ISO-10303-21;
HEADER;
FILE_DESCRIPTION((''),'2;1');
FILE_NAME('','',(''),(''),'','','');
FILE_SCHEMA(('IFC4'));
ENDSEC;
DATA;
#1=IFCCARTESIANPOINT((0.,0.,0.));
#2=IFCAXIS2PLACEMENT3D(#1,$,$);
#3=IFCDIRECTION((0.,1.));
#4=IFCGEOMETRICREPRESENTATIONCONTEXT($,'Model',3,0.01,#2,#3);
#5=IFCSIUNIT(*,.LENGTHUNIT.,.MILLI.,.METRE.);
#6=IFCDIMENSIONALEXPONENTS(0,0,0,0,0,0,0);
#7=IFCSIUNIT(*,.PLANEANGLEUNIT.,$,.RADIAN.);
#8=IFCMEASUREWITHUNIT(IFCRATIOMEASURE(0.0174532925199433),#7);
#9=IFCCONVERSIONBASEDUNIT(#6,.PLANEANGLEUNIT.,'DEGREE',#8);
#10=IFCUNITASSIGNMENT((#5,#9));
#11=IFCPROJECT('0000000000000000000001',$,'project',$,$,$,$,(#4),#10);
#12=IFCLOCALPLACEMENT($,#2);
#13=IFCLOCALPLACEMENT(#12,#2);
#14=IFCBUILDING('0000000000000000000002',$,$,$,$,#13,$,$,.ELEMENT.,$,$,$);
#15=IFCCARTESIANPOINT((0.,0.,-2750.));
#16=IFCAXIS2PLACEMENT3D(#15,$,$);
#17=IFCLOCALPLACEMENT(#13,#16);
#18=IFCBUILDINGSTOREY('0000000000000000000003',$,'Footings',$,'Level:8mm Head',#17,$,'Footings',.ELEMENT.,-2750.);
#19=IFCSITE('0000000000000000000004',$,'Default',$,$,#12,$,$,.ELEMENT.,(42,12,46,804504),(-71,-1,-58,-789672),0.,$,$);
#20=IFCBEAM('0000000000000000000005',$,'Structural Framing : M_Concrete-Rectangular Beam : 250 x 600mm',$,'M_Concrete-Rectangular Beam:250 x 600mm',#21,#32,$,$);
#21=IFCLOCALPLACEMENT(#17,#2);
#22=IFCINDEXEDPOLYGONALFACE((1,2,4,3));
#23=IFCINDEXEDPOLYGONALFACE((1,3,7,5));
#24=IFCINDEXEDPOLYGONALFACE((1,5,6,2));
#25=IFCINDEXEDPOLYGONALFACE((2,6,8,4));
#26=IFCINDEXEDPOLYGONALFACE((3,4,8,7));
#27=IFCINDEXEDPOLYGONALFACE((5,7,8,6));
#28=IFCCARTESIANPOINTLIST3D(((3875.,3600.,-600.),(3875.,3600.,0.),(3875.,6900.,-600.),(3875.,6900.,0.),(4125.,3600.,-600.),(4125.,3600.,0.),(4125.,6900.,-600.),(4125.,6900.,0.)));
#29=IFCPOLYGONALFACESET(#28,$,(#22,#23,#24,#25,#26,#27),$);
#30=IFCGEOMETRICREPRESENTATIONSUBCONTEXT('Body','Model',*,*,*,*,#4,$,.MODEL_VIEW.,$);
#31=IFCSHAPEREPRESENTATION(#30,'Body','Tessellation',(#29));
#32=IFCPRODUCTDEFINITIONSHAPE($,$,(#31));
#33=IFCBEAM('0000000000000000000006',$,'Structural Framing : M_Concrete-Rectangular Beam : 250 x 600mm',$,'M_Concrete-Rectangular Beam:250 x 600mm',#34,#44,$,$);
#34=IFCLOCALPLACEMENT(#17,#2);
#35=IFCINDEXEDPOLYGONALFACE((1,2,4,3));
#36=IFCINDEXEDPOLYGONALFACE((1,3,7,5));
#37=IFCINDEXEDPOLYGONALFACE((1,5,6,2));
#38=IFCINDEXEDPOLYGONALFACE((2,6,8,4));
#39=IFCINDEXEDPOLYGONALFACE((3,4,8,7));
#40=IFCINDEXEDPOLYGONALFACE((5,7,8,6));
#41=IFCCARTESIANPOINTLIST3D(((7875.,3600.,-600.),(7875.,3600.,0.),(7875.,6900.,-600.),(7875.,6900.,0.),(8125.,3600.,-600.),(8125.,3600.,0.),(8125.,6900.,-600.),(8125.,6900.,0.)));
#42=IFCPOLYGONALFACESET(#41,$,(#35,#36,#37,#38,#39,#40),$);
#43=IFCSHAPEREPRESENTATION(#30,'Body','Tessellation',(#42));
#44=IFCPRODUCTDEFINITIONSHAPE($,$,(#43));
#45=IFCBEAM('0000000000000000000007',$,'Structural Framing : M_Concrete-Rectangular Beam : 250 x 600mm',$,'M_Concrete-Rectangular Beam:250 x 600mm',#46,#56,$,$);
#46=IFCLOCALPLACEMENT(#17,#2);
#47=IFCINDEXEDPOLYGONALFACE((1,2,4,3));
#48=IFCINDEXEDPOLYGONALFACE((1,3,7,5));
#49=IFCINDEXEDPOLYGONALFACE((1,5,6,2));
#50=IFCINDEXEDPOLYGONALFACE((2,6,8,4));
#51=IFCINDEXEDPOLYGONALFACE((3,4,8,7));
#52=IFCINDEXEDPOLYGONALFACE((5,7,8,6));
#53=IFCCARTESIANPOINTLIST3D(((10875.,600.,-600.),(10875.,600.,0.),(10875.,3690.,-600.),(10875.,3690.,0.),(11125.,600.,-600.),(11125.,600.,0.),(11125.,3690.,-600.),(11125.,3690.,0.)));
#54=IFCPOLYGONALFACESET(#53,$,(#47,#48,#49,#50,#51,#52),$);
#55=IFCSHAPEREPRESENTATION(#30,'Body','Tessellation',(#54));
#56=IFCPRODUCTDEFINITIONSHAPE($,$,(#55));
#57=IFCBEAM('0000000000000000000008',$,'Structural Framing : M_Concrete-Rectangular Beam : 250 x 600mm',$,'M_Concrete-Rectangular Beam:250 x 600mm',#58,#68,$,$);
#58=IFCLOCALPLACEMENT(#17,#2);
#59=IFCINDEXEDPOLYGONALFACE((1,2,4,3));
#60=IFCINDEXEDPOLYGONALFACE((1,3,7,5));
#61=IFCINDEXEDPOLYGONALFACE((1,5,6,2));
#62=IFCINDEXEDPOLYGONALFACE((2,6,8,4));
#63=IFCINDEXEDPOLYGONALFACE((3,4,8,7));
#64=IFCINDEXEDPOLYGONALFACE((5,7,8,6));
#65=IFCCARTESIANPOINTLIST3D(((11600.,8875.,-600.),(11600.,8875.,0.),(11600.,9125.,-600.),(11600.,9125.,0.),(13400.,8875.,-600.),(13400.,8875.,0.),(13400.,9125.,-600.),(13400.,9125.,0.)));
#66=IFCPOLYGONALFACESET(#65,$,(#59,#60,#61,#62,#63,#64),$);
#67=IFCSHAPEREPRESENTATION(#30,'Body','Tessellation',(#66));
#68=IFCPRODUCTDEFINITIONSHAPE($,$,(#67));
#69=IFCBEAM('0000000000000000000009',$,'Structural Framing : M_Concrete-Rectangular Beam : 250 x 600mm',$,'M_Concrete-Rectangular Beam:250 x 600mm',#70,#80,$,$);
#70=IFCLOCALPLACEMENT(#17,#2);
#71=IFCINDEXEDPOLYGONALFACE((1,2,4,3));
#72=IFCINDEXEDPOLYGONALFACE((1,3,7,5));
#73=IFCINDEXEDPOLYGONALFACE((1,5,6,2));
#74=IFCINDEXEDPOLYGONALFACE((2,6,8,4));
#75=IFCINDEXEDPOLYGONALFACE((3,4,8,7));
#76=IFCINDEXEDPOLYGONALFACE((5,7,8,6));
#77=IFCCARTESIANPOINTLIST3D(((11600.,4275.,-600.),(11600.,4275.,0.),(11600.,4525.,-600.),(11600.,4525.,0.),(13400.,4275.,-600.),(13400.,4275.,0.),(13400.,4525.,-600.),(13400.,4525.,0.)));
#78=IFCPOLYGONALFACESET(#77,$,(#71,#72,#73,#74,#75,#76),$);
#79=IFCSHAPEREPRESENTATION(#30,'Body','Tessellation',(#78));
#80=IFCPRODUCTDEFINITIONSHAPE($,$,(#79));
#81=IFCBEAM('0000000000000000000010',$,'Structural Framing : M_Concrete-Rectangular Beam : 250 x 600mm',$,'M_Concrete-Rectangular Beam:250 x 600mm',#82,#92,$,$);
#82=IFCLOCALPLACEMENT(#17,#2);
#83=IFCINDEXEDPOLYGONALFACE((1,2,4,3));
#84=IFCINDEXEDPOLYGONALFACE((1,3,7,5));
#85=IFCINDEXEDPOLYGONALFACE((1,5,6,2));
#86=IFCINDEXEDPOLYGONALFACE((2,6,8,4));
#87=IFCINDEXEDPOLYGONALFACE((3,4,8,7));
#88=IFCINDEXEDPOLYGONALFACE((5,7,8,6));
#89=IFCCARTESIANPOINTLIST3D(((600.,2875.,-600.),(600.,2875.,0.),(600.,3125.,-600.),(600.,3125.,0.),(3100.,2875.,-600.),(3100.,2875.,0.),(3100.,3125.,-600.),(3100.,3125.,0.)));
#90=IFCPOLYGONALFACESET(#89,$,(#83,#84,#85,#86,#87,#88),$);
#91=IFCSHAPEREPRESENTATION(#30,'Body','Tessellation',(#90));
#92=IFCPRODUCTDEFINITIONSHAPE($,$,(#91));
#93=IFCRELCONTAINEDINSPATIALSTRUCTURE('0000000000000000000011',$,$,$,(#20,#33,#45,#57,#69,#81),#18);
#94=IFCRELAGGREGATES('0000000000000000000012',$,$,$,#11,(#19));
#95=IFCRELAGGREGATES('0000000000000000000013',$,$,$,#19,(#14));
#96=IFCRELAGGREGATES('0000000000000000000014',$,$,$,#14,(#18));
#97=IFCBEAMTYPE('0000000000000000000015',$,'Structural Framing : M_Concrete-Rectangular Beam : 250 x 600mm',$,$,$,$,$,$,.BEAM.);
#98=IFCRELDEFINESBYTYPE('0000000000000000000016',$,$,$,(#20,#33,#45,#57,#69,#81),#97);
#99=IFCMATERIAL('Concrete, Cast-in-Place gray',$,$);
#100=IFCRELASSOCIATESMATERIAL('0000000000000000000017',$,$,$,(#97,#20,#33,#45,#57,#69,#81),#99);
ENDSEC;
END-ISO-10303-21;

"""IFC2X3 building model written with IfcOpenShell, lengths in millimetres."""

from ifc_helpers import new_model, entity, si_unit, converted_unit, direction, frame, frame_2d, origin, origin_2d_with_axis, place, context, subcontext, project, spatial, rectangle, extrude, material, type_object, element, save


model = new_model("IFC2X3")

# Units and contexts
model_context = context("Model", 3, precision=0.01, world=origin(), true_north=direction((0.0, 1.0)))
body_context = subcontext(model_context, "Body", "Model", "MODEL_VIEW")
ifc_project = project(units=[si_unit("LENGTHUNIT", "METRE", prefix="MILLI"), converted_unit("PLANEANGLEUNIT", "DEGREE", entity("IfcRatioMeasure", 0.0174532925199433), si_unit("PLANEANGLEUNIT", "RADIAN"), dimensions=[0, 0, 0, 0, 0, 0, 0])], contexts=[model_context])

# Site, building, storey
site_placement = place(None, origin())
site = spatial("IfcSite", under=ifc_project, at=site_placement, Name="Default", CompositionType="ELEMENT", RefLatitude=(42, 12, 46, 804504), RefLongitude=(-71, -1, -58, -789672), RefElevation=0.0)
building_placement = place(site_placement, origin())
building = spatial("IfcBuilding", under=site, at=building_placement, CompositionType="ELEMENT")
storey_placement = place(building_placement, frame((0.0, 0.0, -2750.0)))
storey = spatial("IfcBuildingStorey", under=building, at=storey_placement, Name="Footings", ObjectType="Level:8mm Head", LongName="Footings", CompositionType="ELEMENT", Elevation=-2750.0)

# Beams
ifc_material = material(Name="Concrete, Cast-in-Place gray")
beam_type = type_object("IfcBeamType", Name="Structural Framing : M_Concrete-Rectangular Beam : 250 x 600mm", PredefinedType="BEAM", material=ifc_material)
beam_1_placement = place(storey_placement, frame((4000.0, 3000.0, 0.0), z_axis=(0.0, 0.0, 1.0), x_axis=(0.0, 1.0, 0.0)))
element("IfcBeam", 1, at=beam_1_placement, inside=storey, type_object=beam_type, material=ifc_material, Name="Structural Framing : M_Concrete-Rectangular Beam : 250 x 600mm", ObjectType="M_Concrete-Rectangular Beam:250 x 600mm", context=body_context, shape_type="SweptSolid", body=[
    extrude(rectangle(XDim=600.0, YDim=250.0, at=frame_2d((0.0, 0.0), x_axis=(1.0, 0.0))), frame((600.0, 0.0, -300.0), z_axis=(1.0, 0.0, 0.0), x_axis=(0.0, 0.0, -1.0)), (0.0, 0.0, 1.0), 3300.0),
])
beam_2_placement = place(storey_placement, frame((8000.0, 3000.0, 0.0), z_axis=(0.0, 0.0, 1.0), x_axis=(0.0, 1.0, 0.0)))
element("IfcBeam", 2, at=beam_2_placement, inside=storey, type_object=beam_type, material=ifc_material, Name="Structural Framing : M_Concrete-Rectangular Beam : 250 x 600mm", ObjectType="M_Concrete-Rectangular Beam:250 x 600mm", context=body_context, shape_type="SweptSolid", body=[
    extrude(rectangle(XDim=600.0, YDim=250.0, at=frame_2d((0.0, 0.0), x_axis=(1.0, 0.0))), frame((600.0, 0.0, -300.0), z_axis=(1.0, 0.0, 0.0), x_axis=(0.0, 0.0, -1.0)), (0.0, 0.0, 1.0), 3300.0),
])
beam_3_placement = place(storey_placement, frame((11000.0, 0.0, 0.0), z_axis=(0.0, 0.0, 1.0), x_axis=(0.0, 1.0, 0.0)))
element("IfcBeam", 3, at=beam_3_placement, inside=storey, type_object=beam_type, material=ifc_material, Name="Structural Framing : M_Concrete-Rectangular Beam : 250 x 600mm", ObjectType="M_Concrete-Rectangular Beam:250 x 600mm", context=body_context, shape_type="SweptSolid", body=[
    extrude(rectangle(XDim=600.0, YDim=250.0, at=origin_2d_with_axis()), frame((600.0, 0.0, -300.0), z_axis=(1.0, 0.0, 0.0), x_axis=(0.0, 0.0, -1.0)), (0.0, 0.0, 1.0), 3090.0),
])
beam_4_placement = place(storey_placement, frame((14000.0, 9000.0, 0.0), z_axis=(0.0, 0.0, 1.0), x_axis=(-1.0, 0.0, 0.0)))
element("IfcBeam", 4, at=beam_4_placement, inside=storey, type_object=beam_type, material=ifc_material, Name="Structural Framing : M_Concrete-Rectangular Beam : 250 x 600mm", ObjectType="M_Concrete-Rectangular Beam:250 x 600mm", context=body_context, shape_type="SweptSolid", body=[
    extrude(rectangle(XDim=600.0, YDim=250.0, at=frame_2d((0.0, 0.0), x_axis=(1.0, 0.0))), frame((600.0, 0.0, -300.0), z_axis=(1.0, 0.0, 0.0), x_axis=(0.0, 0.0, -1.0)), (0.0, 0.0, 1.0), 1800.0),
])
beam_5_placement = place(storey_placement, frame((14000.0, 4400.0, 0.0), z_axis=(0.0, 0.0, 1.0), x_axis=(-1.0, 0.0, 0.0)))
element("IfcBeam", 5, at=beam_5_placement, inside=storey, type_object=beam_type, material=ifc_material, Name="Structural Framing : M_Concrete-Rectangular Beam : 250 x 600mm", ObjectType="M_Concrete-Rectangular Beam:250 x 600mm", context=body_context, shape_type="SweptSolid", body=[
    extrude(rectangle(XDim=600.0, YDim=250.0, at=frame_2d((0.0, 0.0), x_axis=(1.0, 0.0))), frame((600.0, 0.0, -300.0), z_axis=(1.0, 0.0, 0.0), x_axis=(0.0, 0.0, -1.0)), (0.0, 0.0, 1.0), 1800.0),
])
beam_6_placement = place(storey_placement, frame((0.0, 3000.0, 0.0)))
element("IfcBeam", 6, at=beam_6_placement, inside=storey, type_object=beam_type, material=ifc_material, Name="Structural Framing : M_Concrete-Rectangular Beam : 250 x 600mm", ObjectType="M_Concrete-Rectangular Beam:250 x 600mm", context=body_context, shape_type="SweptSolid", body=[
    extrude(rectangle(XDim=600.0, YDim=250.0, at=frame_2d((0.0, 0.0), x_axis=(1.0, 0.0))), frame((600.0, 0.0, -300.0), z_axis=(1.0, 0.0, 0.0), x_axis=(0.0, 0.0, -1.0)), (0.0, 0.0, 1.0), 2500.0),
])

save(model, "model.ifc")
